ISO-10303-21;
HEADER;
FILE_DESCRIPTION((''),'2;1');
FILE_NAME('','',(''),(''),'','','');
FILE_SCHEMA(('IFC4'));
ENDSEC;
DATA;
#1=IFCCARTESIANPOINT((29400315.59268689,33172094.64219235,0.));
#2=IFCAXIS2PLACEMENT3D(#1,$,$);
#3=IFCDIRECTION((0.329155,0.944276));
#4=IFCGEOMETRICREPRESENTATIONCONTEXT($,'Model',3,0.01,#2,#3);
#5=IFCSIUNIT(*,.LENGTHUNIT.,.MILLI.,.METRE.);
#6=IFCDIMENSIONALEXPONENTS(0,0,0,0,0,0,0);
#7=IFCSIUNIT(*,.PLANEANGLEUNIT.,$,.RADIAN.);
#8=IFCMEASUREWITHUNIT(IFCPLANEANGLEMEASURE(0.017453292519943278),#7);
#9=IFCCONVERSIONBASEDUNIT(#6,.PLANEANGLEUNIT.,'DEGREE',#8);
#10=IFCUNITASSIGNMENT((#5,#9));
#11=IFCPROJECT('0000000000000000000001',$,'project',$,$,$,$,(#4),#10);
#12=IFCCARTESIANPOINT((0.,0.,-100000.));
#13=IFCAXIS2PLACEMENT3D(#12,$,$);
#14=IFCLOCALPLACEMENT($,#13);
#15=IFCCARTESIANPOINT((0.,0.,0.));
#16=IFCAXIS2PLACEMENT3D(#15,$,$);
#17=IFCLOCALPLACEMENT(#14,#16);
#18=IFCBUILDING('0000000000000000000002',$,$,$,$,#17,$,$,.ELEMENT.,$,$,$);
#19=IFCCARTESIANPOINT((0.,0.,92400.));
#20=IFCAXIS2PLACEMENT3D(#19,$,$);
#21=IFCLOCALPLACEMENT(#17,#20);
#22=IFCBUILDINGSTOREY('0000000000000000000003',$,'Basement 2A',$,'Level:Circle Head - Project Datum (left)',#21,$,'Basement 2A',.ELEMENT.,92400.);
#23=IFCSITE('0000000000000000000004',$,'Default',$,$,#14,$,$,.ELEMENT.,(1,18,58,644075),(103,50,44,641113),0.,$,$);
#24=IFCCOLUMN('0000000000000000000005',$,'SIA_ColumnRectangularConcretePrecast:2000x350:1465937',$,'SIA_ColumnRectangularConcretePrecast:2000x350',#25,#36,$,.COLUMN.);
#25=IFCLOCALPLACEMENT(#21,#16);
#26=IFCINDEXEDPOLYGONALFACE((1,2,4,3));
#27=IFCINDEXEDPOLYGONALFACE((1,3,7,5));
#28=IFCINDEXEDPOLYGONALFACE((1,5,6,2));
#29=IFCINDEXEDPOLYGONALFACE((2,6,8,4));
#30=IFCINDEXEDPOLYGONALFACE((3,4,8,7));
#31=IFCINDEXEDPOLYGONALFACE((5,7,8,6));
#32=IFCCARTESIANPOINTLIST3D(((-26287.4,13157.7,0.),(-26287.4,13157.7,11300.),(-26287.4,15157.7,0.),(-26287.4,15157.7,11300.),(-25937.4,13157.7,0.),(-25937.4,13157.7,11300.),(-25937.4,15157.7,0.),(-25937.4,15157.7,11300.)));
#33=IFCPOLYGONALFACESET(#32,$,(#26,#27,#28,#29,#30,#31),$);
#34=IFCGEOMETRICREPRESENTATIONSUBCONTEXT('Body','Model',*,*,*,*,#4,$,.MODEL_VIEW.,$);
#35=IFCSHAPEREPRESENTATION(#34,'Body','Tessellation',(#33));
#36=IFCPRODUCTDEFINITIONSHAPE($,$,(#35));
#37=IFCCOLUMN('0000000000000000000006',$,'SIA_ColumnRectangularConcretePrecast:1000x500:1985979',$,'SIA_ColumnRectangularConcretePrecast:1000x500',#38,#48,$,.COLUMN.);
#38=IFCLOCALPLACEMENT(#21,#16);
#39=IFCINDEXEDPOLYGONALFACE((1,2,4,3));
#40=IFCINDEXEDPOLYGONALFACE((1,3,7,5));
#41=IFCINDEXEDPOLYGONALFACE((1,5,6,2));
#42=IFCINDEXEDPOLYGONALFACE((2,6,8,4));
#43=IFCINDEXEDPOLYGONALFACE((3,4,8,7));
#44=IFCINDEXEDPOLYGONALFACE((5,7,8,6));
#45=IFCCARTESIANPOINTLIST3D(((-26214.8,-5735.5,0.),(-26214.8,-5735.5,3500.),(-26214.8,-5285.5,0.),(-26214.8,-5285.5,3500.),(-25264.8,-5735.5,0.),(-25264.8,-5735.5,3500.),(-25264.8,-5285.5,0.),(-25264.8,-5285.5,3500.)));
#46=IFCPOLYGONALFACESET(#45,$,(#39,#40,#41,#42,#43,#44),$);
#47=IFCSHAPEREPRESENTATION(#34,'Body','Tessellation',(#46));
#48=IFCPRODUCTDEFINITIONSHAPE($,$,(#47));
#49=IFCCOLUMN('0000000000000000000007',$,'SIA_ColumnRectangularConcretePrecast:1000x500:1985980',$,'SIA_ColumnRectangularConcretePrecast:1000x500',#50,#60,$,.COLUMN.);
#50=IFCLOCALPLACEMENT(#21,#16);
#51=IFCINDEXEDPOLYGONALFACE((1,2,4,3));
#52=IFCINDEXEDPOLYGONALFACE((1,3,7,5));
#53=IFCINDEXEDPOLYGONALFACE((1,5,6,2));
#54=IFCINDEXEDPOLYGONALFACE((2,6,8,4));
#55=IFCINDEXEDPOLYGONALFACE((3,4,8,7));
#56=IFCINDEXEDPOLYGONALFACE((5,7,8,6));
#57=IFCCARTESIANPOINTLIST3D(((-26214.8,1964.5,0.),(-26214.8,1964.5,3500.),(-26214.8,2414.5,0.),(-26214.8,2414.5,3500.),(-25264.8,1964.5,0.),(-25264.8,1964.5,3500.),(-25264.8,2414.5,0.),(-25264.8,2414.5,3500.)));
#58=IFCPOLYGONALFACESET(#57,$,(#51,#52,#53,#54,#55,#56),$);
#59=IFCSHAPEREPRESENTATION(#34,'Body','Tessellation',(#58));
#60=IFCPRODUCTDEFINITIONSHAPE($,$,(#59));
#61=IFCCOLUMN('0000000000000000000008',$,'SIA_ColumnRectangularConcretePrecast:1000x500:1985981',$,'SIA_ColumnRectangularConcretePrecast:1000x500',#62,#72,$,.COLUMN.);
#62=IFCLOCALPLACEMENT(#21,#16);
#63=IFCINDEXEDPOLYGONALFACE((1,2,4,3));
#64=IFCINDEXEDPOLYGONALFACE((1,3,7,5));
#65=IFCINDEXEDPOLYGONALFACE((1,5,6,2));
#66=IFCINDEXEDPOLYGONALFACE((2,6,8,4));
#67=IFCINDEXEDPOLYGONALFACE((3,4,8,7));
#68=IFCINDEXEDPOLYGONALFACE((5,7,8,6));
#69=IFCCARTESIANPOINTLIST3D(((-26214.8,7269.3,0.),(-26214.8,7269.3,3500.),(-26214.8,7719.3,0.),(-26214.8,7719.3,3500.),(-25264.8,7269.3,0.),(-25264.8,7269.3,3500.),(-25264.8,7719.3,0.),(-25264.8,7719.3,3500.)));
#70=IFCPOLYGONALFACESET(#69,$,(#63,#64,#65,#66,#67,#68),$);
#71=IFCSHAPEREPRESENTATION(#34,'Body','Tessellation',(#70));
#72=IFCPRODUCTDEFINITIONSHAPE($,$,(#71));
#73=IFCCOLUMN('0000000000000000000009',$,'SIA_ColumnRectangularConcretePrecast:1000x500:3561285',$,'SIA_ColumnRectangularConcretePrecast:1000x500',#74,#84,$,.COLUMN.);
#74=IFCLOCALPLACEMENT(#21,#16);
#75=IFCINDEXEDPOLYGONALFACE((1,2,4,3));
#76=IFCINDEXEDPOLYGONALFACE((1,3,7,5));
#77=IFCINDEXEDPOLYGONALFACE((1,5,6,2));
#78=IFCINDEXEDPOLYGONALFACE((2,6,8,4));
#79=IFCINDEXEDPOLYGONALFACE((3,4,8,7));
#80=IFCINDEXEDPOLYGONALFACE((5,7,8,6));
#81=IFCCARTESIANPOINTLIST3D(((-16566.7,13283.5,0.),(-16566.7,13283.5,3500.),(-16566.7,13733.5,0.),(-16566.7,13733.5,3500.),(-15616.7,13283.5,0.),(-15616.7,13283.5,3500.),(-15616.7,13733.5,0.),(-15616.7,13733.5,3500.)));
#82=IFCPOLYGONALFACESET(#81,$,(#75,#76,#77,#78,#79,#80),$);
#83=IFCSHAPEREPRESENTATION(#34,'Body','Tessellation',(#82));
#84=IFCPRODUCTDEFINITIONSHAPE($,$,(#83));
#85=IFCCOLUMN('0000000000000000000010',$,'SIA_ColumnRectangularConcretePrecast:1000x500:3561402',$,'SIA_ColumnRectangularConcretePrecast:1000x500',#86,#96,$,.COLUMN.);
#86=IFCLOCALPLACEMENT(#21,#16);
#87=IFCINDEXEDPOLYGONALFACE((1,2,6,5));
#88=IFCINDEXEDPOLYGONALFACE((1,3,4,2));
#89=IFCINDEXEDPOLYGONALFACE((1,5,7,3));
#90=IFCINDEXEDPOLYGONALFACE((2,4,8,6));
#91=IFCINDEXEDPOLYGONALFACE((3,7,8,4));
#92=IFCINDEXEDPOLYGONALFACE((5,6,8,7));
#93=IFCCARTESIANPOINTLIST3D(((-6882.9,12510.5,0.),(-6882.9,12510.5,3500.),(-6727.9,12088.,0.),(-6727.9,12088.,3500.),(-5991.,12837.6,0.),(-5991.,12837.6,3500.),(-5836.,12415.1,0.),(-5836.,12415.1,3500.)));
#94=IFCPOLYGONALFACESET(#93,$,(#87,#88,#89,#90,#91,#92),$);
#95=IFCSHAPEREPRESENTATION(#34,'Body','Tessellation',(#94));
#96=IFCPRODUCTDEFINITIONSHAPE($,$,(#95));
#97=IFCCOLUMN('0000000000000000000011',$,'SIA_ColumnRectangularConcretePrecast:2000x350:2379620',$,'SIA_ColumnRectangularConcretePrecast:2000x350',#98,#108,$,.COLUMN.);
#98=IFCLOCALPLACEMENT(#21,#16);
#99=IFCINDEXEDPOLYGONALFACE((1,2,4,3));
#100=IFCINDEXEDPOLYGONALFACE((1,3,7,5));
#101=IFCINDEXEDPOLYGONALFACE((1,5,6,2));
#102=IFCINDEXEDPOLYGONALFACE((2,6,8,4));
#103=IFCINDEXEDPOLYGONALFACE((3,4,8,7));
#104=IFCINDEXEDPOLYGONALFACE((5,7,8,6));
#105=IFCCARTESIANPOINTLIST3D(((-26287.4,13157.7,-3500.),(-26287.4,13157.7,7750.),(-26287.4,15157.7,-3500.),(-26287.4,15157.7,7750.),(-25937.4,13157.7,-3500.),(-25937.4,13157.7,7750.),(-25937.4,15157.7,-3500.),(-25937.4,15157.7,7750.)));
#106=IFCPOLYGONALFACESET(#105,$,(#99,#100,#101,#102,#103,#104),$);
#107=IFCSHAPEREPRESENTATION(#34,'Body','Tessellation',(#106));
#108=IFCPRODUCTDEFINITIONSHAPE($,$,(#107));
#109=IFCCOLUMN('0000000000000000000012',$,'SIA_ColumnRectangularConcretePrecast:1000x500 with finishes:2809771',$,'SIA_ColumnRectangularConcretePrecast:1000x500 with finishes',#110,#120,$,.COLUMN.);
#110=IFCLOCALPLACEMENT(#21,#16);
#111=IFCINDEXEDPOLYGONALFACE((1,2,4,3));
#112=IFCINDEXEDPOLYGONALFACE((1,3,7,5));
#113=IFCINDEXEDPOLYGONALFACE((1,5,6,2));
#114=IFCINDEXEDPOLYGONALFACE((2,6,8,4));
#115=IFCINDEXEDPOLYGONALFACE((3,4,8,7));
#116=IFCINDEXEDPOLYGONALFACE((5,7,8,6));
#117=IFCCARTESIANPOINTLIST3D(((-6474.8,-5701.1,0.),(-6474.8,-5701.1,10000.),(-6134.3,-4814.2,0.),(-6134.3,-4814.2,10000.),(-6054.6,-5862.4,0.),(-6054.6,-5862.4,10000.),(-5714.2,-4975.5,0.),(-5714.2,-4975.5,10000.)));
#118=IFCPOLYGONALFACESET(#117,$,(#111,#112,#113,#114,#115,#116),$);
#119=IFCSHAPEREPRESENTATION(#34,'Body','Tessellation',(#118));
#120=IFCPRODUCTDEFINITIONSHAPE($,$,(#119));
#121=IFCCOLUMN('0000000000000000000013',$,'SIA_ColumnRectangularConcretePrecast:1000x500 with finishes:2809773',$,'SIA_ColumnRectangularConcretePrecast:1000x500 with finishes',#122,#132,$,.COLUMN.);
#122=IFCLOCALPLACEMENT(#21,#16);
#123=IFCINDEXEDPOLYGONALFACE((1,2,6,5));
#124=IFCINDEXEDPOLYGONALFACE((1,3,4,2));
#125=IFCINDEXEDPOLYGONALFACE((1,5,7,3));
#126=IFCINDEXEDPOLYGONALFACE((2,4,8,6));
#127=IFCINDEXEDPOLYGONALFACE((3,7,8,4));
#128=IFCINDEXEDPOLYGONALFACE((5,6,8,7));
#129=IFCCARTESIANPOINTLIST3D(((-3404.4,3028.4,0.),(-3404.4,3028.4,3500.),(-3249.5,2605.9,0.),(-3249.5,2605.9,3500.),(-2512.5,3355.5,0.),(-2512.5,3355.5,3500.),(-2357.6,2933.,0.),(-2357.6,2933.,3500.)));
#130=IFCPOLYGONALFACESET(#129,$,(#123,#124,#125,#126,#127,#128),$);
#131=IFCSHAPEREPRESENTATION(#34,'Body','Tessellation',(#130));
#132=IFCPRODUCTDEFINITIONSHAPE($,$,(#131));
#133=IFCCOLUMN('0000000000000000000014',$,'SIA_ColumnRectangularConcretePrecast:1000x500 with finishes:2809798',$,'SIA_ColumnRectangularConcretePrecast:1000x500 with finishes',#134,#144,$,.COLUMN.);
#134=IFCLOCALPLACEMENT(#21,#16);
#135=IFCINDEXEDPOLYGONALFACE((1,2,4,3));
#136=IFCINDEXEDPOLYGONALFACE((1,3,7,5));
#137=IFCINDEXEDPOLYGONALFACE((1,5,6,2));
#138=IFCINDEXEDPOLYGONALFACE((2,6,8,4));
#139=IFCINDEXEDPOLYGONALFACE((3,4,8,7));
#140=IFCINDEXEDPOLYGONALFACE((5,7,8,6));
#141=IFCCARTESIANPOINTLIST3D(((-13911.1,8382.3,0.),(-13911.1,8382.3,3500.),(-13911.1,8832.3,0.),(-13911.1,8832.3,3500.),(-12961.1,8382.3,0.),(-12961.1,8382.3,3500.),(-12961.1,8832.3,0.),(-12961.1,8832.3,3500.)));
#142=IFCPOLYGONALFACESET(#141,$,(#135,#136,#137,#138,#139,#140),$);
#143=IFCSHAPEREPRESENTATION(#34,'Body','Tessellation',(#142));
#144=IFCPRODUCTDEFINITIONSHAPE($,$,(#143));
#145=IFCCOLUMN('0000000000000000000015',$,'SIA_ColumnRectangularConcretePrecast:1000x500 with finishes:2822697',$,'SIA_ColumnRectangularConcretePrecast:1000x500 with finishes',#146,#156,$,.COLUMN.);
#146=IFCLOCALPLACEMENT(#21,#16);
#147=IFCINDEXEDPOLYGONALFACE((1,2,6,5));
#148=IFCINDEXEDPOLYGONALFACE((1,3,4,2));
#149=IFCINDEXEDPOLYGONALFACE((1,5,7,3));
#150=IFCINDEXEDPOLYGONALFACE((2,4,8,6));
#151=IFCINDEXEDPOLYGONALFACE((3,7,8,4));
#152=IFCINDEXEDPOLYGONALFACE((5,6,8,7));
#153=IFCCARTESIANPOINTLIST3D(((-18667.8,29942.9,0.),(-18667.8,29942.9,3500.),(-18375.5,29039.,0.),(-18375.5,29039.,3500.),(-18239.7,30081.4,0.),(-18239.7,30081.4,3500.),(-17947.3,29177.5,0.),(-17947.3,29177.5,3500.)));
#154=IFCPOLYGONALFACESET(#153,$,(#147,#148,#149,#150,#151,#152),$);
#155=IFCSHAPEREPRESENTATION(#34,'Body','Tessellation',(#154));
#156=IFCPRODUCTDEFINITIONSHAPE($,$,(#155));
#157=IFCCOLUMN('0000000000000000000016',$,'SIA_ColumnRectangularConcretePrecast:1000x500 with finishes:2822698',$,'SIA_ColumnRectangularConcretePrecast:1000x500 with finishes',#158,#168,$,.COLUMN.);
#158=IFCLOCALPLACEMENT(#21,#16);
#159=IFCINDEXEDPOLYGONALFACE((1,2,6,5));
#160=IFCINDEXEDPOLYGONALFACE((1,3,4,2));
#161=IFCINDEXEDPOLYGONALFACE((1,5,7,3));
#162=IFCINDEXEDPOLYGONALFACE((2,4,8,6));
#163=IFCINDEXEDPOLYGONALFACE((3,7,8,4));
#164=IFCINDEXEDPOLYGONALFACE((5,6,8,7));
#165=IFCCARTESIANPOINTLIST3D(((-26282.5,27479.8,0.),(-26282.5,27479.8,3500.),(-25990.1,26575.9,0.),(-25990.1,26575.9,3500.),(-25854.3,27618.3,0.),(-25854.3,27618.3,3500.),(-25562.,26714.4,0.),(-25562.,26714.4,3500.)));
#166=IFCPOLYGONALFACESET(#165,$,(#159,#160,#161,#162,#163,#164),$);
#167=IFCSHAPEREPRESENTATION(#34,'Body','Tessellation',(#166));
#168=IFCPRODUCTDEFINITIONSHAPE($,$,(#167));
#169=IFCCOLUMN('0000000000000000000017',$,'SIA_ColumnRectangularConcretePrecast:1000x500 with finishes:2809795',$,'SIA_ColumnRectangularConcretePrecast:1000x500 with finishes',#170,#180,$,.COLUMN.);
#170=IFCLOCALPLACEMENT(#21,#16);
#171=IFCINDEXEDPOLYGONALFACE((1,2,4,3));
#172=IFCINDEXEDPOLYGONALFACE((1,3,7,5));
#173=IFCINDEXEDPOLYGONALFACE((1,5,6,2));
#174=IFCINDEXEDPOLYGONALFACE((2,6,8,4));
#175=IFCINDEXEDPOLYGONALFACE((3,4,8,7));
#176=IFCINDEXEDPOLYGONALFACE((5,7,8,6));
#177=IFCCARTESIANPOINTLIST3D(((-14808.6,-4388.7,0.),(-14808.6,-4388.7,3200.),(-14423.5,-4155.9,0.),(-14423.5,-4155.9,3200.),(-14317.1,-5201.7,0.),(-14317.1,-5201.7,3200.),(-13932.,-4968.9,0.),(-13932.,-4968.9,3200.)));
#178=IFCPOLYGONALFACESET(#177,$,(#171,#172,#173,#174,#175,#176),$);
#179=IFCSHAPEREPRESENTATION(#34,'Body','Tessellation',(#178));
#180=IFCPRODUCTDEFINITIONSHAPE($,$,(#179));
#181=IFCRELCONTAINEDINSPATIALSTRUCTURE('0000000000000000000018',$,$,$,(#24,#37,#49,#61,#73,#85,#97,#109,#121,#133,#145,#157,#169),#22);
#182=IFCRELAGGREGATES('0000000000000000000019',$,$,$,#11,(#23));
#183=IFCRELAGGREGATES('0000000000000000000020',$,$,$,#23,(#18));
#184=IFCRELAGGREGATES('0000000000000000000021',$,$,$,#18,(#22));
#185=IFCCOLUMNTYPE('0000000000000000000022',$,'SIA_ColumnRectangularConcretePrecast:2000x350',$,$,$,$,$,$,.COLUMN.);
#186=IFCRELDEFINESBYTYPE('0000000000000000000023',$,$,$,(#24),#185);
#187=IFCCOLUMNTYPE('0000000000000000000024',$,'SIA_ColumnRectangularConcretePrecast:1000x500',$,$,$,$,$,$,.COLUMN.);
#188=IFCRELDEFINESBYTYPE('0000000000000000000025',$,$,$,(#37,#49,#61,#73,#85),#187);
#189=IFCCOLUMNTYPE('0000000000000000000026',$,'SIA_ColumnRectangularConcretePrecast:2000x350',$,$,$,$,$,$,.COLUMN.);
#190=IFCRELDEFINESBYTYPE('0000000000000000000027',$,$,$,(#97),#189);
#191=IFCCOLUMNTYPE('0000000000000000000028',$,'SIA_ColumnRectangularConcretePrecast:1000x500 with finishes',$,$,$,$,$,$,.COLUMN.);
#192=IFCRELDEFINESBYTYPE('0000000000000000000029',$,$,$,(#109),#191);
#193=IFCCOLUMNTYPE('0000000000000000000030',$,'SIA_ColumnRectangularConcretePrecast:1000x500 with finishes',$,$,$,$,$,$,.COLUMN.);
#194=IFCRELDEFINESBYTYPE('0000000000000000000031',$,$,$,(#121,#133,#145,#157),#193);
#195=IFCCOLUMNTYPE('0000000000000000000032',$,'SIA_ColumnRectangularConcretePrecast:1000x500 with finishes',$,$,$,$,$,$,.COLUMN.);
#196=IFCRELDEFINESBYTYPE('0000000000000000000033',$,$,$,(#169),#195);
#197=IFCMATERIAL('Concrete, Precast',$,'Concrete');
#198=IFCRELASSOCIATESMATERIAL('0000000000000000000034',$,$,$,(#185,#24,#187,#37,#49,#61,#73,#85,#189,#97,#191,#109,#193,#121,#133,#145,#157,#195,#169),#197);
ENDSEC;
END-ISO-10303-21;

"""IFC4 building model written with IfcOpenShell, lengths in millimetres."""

from ifc_helpers import new_model, entity, si_unit, converted_unit, direction, frame, origin, place, context, subcontext, project, spatial, indexed_curve, outline, extrude, source, transform, mapped, material, type_object, type_shapes, element, save


model = new_model("IFC4")

# Units and contexts
model_context = context("Model", 3, precision=0.01, world=frame((29400315.59268689, 33172094.64219235, 0.0)), true_north=direction((0.329155, 0.944276)))
body_context = subcontext(model_context, "Body", "Model", "MODEL_VIEW")
ifc_project = project(units=[si_unit("LENGTHUNIT", "METRE", prefix="MILLI"), converted_unit("PLANEANGLEUNIT", "DEGREE", entity("IfcPlaneAngleMeasure", 0.017453292519943278), si_unit("PLANEANGLEUNIT", "RADIAN"), dimensions=[0, 0, 0, 0, 0, 0, 0])], contexts=[model_context])

# Site, building, storey
site_placement = place(None, frame((0.0, 0.0, -100000.0)))
site = spatial("IfcSite", under=ifc_project, at=site_placement, Name="Default", CompositionType="ELEMENT", RefLatitude=(1, 18, 58, 644075), RefLongitude=(103, 50, 44, 641113), RefElevation=0.0)
building_placement = place(site_placement, origin())
building = spatial("IfcBuilding", under=site, at=building_placement, CompositionType="ELEMENT")
storey_placement = place(building_placement, frame((0.0, 0.0, 92400.0)))
storey = spatial("IfcBuildingStorey", under=building, at=storey_placement, Name="Basement 2A", ObjectType="Level:Circle Head - Project Datum (left)", LongName="Basement 2A", CompositionType="ELEMENT", Elevation=92400.0)

# Columns
ifc_material_1 = material(Name="Concrete, Precast", Category="Concrete")
column_type_1 = type_object("IfcColumnType", Name="SIA_ColumnRectangularConcretePrecast:2000x350", PredefinedType="COLUMN", material=ifc_material_1)
shared_shape_1 = source(origin(), body_context, "Body", "SweptSolid", [
    extrude(outline(indexed_curve([(-175.0, -1000.0), (175.0, -1000.0), (175.0, 1000.0), (-175.0, 1000.0), (-175.0, -1000.0)], self_intersect=False)), frame((0.0, 0.0, 92400.0), z_axis=(0.0, 0.0, 1.0), x_axis=(-1.0, 0.0, 0.0)), (0.0, 0.0, 1.0), 11300.0),
])
type_shapes(column_type_1, [shared_shape_1])
column_1_placement = place(storey_placement, frame((-26112.4, 14157.7, -92400.0)))
element("IfcColumn", 1, at=column_1_placement, inside=storey, type_object=column_type_1, material=ifc_material_1, Name="SIA_ColumnRectangularConcretePrecast:2000x350:1465937", ObjectType="SIA_ColumnRectangularConcretePrecast:2000x350", PredefinedType="COLUMN", context=body_context, shape_type="MappedRepresentation", body=[
    mapped(shared_shape_1, transform((0.0, 0.0, 0.0), scale=1.0)),
])
column_type_2 = type_object("IfcColumnType", Name="SIA_ColumnRectangularConcretePrecast:1000x500", PredefinedType="COLUMN", material=ifc_material_1)
shared_shape_2 = source(origin(), body_context, "Body", "SweptSolid", [
    extrude(outline(indexed_curve([(-225.0, -475.0), (225.0, -475.0), (225.0, 475.0), (-225.0, 475.0), (-225.0, -475.0)], self_intersect=False)), frame((0.0, 0.0, 92400.0), z_axis=(0.0, 0.0, 1.0), x_axis=(-1.0, 0.0, 0.0)), (0.0, 0.0, 1.0), 3500.0),
])
type_shapes(column_type_2, [shared_shape_2])
for number, where, z_axis, x_axis, name in (
    (2, (-25739.8, -5510.5, -92400.0), (0.0, 0.0, 1.0), (0.0, -1.0, 0.0), "SIA_ColumnRectangularConcretePrecast:1000x500:1985979"),
    (3, (-25739.8, 2189.5, -92400.0), (0.0, 0.0, 1.0), (0.0, -1.0, 0.0), "SIA_ColumnRectangularConcretePrecast:1000x500:1985980"),
    (4, (-25739.8, 7494.3, -92400.0), (0.0, 0.0, 1.0), (0.0, -1.0, 0.0), "SIA_ColumnRectangularConcretePrecast:1000x500:1985981"),
    (5, (-16091.7, 13508.5, -92400.0), (0.0, 0.0, 1.0), (0.0, -1.0, 0.0), "SIA_ColumnRectangularConcretePrecast:1000x500:3561285"),
    (6, (-6359.5, 12462.8, -92400.0), (0.0, 0.0, 1.0), (-0.344314, 0.938855, 0.0), "SIA_ColumnRectangularConcretePrecast:1000x500:3561402"),
):
    element("IfcColumn", number, at=place(storey_placement, frame(where, z_axis=z_axis, x_axis=x_axis)), inside=storey, type_object=column_type_2, material=ifc_material_1, Name=name, ObjectType="SIA_ColumnRectangularConcretePrecast:1000x500", PredefinedType="COLUMN", context=body_context, shape_type="MappedRepresentation", body=[
        mapped(shared_shape_2, transform((0.0, 0.0, 0.0), scale=1.0)),
    ])
column_type_3 = type_object("IfcColumnType", Name="SIA_ColumnRectangularConcretePrecast:2000x350", PredefinedType="COLUMN", material=ifc_material_1)
shared_shape_3 = source(origin(), body_context, "Body", "SweptSolid", [
    extrude(outline(indexed_curve([(-175.0, -1000.0), (175.0, -1000.0), (175.0, 1000.0), (-175.0, 1000.0), (-175.0, -1000.0)], self_intersect=False)), frame((0.0, 0.0, 88900.0), z_axis=(0.0, 0.0, 1.0), x_axis=(-1.0, 0.0, 0.0)), (0.0, 0.0, 1.0), 11250.0),
])
type_shapes(column_type_3, [shared_shape_3])
column_2_placement = place(storey_placement, frame((-26112.4, 14157.7, -92400.0)))
element("IfcColumn", 7, at=column_2_placement, inside=storey, type_object=column_type_3, material=ifc_material_1, Name="SIA_ColumnRectangularConcretePrecast:2000x350:2379620", ObjectType="SIA_ColumnRectangularConcretePrecast:2000x350", PredefinedType="COLUMN", context=body_context, shape_type="MappedRepresentation", body=[
    mapped(shared_shape_3, transform((0.0, 0.0, 0.0), scale=1.0)),
])
column_type_4 = type_object("IfcColumnType", Name="SIA_ColumnRectangularConcretePrecast:1000x500 with finishes", PredefinedType="COLUMN", material=ifc_material_1)
shared_shape_4 = source(origin(), body_context, "Body", "SweptSolid", [
    extrude(outline(indexed_curve([(-225.0, -475.0), (225.0, -475.0), (225.0, 475.0), (-225.0, 475.0), (-225.0, -475.0)], self_intersect=False)), frame((-6094.5, -5338.3, 92400.0), z_axis=(0.0, 0.0, 1.0), x_axis=(-0.93358, 0.358368, 0.0)), (0.0, 0.0, 1.0), 10000.0),
])
type_shapes(column_type_4, [shared_shape_4])
column_3_placement = place(storey_placement, frame((0.0, 0.0, -92400.0)))
element("IfcColumn", 8, at=column_3_placement, inside=storey, type_object=column_type_4, material=ifc_material_1, Name="SIA_ColumnRectangularConcretePrecast:1000x500 with finishes:2809771", ObjectType="SIA_ColumnRectangularConcretePrecast:1000x500 with finishes", PredefinedType="COLUMN", context=body_context, shape_type="MappedRepresentation", body=[
    mapped(shared_shape_4, transform((0.0, 0.0, 0.0), scale=1.0)),
])
column_type_5 = type_object("IfcColumnType", Name="SIA_ColumnRectangularConcretePrecast:1000x500 with finishes", PredefinedType="COLUMN", material=ifc_material_1)
shared_shape_5 = source(origin(), body_context, "Body", "SweptSolid", [
    extrude(outline(indexed_curve([(-225.0, -475.0), (225.0, -475.0), (225.0, 475.0), (-225.0, 475.0), (-225.0, -475.0)], self_intersect=False)), frame((0.0, 0.0, 92400.0), z_axis=(0.0, 0.0, 1.0), x_axis=(-1.0, 0.0, 0.0)), (0.0, 0.0, 1.0), 3500.0),
])
type_shapes(column_type_5, [shared_shape_5])
for number, where, z_axis, x_axis, name in (
    (9, (-2881.0, 2980.7, -92400.0), (0.0, 0.0, 1.0), (0.344366, -0.938835, 0.0), "SIA_ColumnRectangularConcretePrecast:1000x500 with finishes:2809773"),
    (10, (-13436.1, 8607.3, -92400.0), (0.0, 0.0, 1.0), (0.0, -1.0, 0.0), "SIA_ColumnRectangularConcretePrecast:1000x500 with finishes:2809798"),
    (11, (-18307.6, 29560.2, -92400.0), (0.0, 0.0, 1.0), (0.95147, 0.307742, 0.0), "SIA_ColumnRectangularConcretePrecast:1000x500 with finishes:2822697"),
    (12, (-25922.2, 27097.1, -92400.0), (0.0, 0.0, 1.0), (0.95147, 0.307742, 0.0), "SIA_ColumnRectangularConcretePrecast:1000x500 with finishes:2822698"),
):
    element("IfcColumn", number, at=place(storey_placement, frame(where, z_axis=z_axis, x_axis=x_axis)), inside=storey, type_object=column_type_5, material=ifc_material_1, Name=name, ObjectType="SIA_ColumnRectangularConcretePrecast:1000x500 with finishes", PredefinedType="COLUMN", context=body_context, shape_type="MappedRepresentation", body=[
        mapped(shared_shape_5, transform((0.0, 0.0, 0.0), scale=1.0)),
    ])
column_type_6 = type_object("IfcColumnType", Name="SIA_ColumnRectangularConcretePrecast:1000x500 with finishes", PredefinedType="COLUMN", material=ifc_material_1)
shared_shape_6 = source(origin(), body_context, "Body", "SweptSolid", [
    extrude(outline(indexed_curve([(-225.0, -475.0), (225.0, -475.0), (225.0, 475.0), (-225.0, 475.0), (-225.0, -475.0)], self_intersect=False)), frame((-14370.3, -4678.8, 92400.0), z_axis=(0.0, 0.0, 1.0), x_axis=(-0.855803, -0.517302, 0.0)), (0.0, 0.0, 1.0), 3200.0),
])
type_shapes(column_type_6, [shared_shape_6])
column_4_placement = place(storey_placement, frame((0.0, 0.0, -92400.0)))
element("IfcColumn", 13, at=column_4_placement, inside=storey, type_object=column_type_6, material=ifc_material_1, Name="SIA_ColumnRectangularConcretePrecast:1000x500 with finishes:2809795", ObjectType="SIA_ColumnRectangularConcretePrecast:1000x500 with finishes", PredefinedType="COLUMN", context=body_context, shape_type="MappedRepresentation", body=[
    mapped(shared_shape_6, transform((0.0, 0.0, 0.0), scale=1.0)),
])

save(model, "model.ifc")
